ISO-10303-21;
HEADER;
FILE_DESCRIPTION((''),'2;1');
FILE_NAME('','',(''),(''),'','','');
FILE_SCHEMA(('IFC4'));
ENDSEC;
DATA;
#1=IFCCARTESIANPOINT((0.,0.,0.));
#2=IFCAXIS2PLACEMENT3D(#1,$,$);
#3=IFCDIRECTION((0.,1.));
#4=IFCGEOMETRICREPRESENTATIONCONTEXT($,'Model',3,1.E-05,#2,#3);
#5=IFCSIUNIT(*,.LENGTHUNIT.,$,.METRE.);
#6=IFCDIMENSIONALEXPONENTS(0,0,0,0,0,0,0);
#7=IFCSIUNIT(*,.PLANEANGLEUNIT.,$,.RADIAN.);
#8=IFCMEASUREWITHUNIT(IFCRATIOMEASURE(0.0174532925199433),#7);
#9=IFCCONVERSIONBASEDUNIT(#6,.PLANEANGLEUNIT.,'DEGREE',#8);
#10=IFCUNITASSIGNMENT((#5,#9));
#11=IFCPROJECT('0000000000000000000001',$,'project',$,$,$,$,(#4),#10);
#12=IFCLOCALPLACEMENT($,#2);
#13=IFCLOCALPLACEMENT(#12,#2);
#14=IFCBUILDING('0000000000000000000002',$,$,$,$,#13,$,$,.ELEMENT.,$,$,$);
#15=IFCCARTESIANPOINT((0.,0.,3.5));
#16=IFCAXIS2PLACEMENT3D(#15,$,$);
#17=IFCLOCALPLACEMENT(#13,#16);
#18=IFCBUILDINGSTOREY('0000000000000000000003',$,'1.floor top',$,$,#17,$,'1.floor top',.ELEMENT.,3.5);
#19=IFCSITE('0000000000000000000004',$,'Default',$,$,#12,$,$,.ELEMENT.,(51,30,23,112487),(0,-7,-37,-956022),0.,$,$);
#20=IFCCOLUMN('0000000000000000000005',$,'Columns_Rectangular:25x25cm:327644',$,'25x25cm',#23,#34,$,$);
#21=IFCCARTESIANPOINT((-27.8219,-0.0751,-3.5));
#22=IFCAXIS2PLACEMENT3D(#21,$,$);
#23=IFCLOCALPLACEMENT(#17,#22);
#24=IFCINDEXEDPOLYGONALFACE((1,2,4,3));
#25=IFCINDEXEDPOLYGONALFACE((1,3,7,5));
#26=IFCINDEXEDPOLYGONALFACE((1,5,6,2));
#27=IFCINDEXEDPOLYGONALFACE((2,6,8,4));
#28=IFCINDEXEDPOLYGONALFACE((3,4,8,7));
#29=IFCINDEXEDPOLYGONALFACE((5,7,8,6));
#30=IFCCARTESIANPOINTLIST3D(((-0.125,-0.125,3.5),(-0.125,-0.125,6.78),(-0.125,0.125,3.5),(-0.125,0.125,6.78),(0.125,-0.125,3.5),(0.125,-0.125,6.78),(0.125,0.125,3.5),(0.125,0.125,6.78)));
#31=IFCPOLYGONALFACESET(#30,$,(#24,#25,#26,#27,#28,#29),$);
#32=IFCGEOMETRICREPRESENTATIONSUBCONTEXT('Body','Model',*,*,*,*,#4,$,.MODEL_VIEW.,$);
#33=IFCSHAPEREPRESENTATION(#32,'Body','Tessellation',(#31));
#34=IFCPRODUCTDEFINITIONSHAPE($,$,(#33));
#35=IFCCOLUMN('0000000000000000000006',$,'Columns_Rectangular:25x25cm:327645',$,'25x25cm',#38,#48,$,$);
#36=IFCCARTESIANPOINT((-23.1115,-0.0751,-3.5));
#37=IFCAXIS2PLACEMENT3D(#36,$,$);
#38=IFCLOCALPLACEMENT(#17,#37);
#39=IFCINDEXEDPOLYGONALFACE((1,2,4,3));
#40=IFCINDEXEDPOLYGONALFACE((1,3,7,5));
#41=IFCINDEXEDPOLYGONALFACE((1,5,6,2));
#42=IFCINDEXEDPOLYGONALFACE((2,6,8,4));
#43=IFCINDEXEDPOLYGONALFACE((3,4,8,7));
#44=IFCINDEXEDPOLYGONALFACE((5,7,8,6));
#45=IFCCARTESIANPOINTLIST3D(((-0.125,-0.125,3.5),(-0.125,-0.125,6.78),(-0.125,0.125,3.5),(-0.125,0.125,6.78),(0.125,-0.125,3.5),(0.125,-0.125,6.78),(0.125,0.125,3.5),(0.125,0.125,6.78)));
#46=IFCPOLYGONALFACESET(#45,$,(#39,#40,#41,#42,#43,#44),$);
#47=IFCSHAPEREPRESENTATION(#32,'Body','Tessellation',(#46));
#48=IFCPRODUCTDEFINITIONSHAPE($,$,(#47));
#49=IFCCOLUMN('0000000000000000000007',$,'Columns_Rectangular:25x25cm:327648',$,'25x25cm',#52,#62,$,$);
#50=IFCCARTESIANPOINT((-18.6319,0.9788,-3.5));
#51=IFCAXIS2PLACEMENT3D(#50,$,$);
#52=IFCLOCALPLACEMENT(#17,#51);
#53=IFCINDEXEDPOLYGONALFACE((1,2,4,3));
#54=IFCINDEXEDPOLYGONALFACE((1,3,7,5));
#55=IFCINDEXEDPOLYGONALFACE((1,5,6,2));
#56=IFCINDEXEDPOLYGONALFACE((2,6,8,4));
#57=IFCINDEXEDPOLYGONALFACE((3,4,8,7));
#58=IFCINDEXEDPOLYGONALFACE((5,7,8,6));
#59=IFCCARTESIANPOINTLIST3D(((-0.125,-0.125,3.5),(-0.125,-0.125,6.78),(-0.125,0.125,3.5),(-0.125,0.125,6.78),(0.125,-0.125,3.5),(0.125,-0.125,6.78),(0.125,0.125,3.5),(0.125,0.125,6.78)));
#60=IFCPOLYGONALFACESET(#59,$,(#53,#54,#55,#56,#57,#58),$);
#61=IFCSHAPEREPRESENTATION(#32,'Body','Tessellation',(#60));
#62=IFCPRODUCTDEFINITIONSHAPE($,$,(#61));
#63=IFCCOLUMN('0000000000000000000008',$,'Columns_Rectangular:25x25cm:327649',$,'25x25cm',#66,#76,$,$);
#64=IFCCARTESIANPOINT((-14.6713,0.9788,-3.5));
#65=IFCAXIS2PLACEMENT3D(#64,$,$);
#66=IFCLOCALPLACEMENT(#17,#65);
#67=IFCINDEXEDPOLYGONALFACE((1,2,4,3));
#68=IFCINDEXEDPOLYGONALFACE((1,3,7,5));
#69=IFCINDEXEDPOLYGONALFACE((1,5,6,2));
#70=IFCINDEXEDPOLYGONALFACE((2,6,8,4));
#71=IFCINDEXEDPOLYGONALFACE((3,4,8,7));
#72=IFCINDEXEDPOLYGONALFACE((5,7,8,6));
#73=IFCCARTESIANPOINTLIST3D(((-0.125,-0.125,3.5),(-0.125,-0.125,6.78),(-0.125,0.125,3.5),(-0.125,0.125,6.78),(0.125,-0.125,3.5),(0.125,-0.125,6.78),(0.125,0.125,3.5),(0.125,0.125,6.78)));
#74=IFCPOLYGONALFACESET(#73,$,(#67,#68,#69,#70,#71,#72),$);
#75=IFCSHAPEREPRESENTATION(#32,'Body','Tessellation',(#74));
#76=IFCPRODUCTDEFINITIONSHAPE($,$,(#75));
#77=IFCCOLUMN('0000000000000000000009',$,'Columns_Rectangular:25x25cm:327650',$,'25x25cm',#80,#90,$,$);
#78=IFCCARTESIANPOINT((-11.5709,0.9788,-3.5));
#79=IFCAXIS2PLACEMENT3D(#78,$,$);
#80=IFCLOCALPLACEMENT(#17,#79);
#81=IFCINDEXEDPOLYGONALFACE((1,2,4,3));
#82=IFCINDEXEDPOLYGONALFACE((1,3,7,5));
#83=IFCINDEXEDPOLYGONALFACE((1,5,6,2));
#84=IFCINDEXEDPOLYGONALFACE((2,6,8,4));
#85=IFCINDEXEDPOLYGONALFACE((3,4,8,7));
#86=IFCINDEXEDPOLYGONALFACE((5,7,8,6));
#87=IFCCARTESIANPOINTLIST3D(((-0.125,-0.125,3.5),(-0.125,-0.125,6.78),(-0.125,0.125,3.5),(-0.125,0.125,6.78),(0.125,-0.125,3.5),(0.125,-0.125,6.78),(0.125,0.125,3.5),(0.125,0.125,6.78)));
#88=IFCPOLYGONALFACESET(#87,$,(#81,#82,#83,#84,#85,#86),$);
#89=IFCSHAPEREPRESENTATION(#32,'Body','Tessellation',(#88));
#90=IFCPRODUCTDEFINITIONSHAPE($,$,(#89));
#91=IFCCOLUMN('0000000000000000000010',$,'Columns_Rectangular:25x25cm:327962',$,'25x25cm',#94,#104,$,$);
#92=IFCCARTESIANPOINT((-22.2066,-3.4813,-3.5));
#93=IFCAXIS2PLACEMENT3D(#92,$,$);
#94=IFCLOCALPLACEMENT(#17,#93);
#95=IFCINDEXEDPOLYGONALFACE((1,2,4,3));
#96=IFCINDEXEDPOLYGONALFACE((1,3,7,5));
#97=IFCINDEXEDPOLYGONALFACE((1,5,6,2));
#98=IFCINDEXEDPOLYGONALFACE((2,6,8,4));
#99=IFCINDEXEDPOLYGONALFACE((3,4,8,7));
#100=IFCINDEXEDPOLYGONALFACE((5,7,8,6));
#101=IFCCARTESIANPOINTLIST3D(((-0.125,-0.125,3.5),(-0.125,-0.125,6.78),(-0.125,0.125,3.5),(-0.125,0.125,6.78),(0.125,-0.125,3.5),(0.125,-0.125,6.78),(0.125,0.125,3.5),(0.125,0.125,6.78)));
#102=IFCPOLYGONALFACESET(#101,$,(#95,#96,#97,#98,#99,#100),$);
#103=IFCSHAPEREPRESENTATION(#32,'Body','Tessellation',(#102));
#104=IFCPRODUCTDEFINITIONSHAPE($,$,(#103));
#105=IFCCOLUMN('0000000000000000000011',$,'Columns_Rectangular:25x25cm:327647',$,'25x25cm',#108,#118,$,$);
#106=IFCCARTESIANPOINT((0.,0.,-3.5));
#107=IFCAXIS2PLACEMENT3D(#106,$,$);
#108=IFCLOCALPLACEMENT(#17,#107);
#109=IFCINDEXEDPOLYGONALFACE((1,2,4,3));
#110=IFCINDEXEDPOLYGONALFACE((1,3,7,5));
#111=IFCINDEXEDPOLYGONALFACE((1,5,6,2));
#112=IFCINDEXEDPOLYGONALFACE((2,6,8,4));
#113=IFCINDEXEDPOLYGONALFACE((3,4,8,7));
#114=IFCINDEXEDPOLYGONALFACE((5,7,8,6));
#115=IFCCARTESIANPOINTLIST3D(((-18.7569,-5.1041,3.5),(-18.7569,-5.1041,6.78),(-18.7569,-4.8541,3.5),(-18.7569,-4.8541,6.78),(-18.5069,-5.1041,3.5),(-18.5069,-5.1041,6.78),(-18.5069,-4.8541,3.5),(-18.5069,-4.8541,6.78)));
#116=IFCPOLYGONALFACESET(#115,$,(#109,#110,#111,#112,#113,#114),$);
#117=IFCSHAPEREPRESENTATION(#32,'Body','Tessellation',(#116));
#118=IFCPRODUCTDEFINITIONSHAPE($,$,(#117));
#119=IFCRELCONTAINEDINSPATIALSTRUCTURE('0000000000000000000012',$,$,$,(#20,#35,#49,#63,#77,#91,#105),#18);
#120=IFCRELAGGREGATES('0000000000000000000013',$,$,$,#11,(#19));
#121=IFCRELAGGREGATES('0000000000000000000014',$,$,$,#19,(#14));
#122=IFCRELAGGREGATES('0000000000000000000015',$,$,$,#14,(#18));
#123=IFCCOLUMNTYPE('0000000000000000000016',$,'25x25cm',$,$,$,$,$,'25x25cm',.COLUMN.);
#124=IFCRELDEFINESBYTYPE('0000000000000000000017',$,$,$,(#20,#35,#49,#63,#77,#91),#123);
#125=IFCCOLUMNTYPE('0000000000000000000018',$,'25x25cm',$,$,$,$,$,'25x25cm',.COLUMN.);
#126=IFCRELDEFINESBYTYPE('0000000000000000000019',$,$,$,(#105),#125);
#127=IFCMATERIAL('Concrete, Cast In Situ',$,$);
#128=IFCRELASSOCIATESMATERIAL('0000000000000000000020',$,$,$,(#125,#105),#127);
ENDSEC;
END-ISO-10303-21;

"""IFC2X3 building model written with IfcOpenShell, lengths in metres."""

from ifc_helpers import new_model, entity, si_unit, converted_unit, direction, frame, frame_2d, origin, origin_2d_with_axis, place, context, subcontext, project, spatial, rectangle, extrude, source, transform, mapped, material, type_object, type_shapes, element, save


model = new_model("IFC2X3")

# Units and contexts
model_context = context("Model", 3, precision=1e-05, world=origin(), true_north=direction((0.0, 1.0)))
body_context = subcontext(model_context, "Body", "Model", "MODEL_VIEW")
ifc_project = project(units=[si_unit("LENGTHUNIT", "METRE"), converted_unit("PLANEANGLEUNIT", "DEGREE", entity("IfcRatioMeasure", 0.0174532925199433), si_unit("PLANEANGLEUNIT", "RADIAN"), dimensions=[0, 0, 0, 0, 0, 0, 0])], contexts=[model_context])

# Site, building, storey
site_placement = place(None, origin())
site = spatial("IfcSite", under=ifc_project, at=site_placement, Name="Default", CompositionType="ELEMENT", RefLatitude=(51, 30, 23, 112487), RefLongitude=(0, -7, -37, -956022), RefElevation=0.0)
building_placement = place(site_placement, origin())
building = spatial("IfcBuilding", under=site, at=building_placement, CompositionType="ELEMENT")
storey_placement = place(building_placement, frame((0.0, 0.0, 3.5)))
storey = spatial("IfcBuildingStorey", under=building, at=storey_placement, Name="1.floor top", LongName="1.floor top", CompositionType="ELEMENT", Elevation=3.5)

# Columns
column_type_1 = type_object("IfcColumnType", Name="25x25cm", ElementType="25x25cm", PredefinedType="COLUMN")
shared_shape_1 = source(origin(), body_context, "Body", "SweptSolid", [
    extrude(rectangle(XDim=0.25, YDim=0.25, at=origin_2d_with_axis()), frame((0.0, 0.0, 3.5), z_axis=(0.0, 0.0, 1.0), x_axis=(0.0, -1.0, 0.0)), (0.0, 0.0, 1.0), 3.28),
])
type_shapes(column_type_1, [shared_shape_1])
for number, where, name in (
    (1, (-27.8219, -0.0751, -3.5), "Columns_Rectangular:25x25cm:327644"),
    (2, (-23.1115, -0.0751, -3.5), "Columns_Rectangular:25x25cm:327645"),
    (3, (-18.6319, 0.9788, -3.5), "Columns_Rectangular:25x25cm:327648"),
    (4, (-14.6713, 0.9788, -3.5), "Columns_Rectangular:25x25cm:327649"),
    (5, (-11.5709, 0.9788, -3.5), "Columns_Rectangular:25x25cm:327650"),
    (6, (-22.2066, -3.4813, -3.5), "Columns_Rectangular:25x25cm:327962"),
):
    element("IfcColumn", number, at=place(storey_placement, frame(where)), inside=storey, type_object=column_type_1, Name=name, ObjectType="25x25cm", context=body_context, shape_type="MappedRepresentation", body=[
        mapped(shared_shape_1, transform((0.0, 0.0, 0.0), scale=1.0)),
    ])
ifc_material_1 = material(Name="Concrete, Cast In Situ")
column_type_2 = type_object("IfcColumnType", Name="25x25cm", ElementType="25x25cm", PredefinedType="COLUMN", material=ifc_material_1)
shared_shape_2 = source(origin(), body_context, "Body", "SweptSolid", [
    extrude(rectangle(XDim=0.25, YDim=0.25, at=frame_2d((0.0, 0.0), x_axis=(1.0, 0.0))), frame((-18.6319, -4.9791, 3.5), z_axis=(0.0, 0.0, 1.0), x_axis=(0.0, -1.0, 0.0)), (0.0, 0.0, 1.0), 3.28),
])
type_shapes(column_type_2, [shared_shape_2])
column_placement = place(storey_placement, frame((0.0, 0.0, -3.5)))
element("IfcColumn", 7, at=column_placement, inside=storey, type_object=column_type_2, material=ifc_material_1, Name="Columns_Rectangular:25x25cm:327647", ObjectType="25x25cm", context=body_context, shape_type="MappedRepresentation", body=[
    mapped(shared_shape_2, transform((0.0, 0.0, 0.0), scale=1.0)),
])

save(model, "model.ifc")
